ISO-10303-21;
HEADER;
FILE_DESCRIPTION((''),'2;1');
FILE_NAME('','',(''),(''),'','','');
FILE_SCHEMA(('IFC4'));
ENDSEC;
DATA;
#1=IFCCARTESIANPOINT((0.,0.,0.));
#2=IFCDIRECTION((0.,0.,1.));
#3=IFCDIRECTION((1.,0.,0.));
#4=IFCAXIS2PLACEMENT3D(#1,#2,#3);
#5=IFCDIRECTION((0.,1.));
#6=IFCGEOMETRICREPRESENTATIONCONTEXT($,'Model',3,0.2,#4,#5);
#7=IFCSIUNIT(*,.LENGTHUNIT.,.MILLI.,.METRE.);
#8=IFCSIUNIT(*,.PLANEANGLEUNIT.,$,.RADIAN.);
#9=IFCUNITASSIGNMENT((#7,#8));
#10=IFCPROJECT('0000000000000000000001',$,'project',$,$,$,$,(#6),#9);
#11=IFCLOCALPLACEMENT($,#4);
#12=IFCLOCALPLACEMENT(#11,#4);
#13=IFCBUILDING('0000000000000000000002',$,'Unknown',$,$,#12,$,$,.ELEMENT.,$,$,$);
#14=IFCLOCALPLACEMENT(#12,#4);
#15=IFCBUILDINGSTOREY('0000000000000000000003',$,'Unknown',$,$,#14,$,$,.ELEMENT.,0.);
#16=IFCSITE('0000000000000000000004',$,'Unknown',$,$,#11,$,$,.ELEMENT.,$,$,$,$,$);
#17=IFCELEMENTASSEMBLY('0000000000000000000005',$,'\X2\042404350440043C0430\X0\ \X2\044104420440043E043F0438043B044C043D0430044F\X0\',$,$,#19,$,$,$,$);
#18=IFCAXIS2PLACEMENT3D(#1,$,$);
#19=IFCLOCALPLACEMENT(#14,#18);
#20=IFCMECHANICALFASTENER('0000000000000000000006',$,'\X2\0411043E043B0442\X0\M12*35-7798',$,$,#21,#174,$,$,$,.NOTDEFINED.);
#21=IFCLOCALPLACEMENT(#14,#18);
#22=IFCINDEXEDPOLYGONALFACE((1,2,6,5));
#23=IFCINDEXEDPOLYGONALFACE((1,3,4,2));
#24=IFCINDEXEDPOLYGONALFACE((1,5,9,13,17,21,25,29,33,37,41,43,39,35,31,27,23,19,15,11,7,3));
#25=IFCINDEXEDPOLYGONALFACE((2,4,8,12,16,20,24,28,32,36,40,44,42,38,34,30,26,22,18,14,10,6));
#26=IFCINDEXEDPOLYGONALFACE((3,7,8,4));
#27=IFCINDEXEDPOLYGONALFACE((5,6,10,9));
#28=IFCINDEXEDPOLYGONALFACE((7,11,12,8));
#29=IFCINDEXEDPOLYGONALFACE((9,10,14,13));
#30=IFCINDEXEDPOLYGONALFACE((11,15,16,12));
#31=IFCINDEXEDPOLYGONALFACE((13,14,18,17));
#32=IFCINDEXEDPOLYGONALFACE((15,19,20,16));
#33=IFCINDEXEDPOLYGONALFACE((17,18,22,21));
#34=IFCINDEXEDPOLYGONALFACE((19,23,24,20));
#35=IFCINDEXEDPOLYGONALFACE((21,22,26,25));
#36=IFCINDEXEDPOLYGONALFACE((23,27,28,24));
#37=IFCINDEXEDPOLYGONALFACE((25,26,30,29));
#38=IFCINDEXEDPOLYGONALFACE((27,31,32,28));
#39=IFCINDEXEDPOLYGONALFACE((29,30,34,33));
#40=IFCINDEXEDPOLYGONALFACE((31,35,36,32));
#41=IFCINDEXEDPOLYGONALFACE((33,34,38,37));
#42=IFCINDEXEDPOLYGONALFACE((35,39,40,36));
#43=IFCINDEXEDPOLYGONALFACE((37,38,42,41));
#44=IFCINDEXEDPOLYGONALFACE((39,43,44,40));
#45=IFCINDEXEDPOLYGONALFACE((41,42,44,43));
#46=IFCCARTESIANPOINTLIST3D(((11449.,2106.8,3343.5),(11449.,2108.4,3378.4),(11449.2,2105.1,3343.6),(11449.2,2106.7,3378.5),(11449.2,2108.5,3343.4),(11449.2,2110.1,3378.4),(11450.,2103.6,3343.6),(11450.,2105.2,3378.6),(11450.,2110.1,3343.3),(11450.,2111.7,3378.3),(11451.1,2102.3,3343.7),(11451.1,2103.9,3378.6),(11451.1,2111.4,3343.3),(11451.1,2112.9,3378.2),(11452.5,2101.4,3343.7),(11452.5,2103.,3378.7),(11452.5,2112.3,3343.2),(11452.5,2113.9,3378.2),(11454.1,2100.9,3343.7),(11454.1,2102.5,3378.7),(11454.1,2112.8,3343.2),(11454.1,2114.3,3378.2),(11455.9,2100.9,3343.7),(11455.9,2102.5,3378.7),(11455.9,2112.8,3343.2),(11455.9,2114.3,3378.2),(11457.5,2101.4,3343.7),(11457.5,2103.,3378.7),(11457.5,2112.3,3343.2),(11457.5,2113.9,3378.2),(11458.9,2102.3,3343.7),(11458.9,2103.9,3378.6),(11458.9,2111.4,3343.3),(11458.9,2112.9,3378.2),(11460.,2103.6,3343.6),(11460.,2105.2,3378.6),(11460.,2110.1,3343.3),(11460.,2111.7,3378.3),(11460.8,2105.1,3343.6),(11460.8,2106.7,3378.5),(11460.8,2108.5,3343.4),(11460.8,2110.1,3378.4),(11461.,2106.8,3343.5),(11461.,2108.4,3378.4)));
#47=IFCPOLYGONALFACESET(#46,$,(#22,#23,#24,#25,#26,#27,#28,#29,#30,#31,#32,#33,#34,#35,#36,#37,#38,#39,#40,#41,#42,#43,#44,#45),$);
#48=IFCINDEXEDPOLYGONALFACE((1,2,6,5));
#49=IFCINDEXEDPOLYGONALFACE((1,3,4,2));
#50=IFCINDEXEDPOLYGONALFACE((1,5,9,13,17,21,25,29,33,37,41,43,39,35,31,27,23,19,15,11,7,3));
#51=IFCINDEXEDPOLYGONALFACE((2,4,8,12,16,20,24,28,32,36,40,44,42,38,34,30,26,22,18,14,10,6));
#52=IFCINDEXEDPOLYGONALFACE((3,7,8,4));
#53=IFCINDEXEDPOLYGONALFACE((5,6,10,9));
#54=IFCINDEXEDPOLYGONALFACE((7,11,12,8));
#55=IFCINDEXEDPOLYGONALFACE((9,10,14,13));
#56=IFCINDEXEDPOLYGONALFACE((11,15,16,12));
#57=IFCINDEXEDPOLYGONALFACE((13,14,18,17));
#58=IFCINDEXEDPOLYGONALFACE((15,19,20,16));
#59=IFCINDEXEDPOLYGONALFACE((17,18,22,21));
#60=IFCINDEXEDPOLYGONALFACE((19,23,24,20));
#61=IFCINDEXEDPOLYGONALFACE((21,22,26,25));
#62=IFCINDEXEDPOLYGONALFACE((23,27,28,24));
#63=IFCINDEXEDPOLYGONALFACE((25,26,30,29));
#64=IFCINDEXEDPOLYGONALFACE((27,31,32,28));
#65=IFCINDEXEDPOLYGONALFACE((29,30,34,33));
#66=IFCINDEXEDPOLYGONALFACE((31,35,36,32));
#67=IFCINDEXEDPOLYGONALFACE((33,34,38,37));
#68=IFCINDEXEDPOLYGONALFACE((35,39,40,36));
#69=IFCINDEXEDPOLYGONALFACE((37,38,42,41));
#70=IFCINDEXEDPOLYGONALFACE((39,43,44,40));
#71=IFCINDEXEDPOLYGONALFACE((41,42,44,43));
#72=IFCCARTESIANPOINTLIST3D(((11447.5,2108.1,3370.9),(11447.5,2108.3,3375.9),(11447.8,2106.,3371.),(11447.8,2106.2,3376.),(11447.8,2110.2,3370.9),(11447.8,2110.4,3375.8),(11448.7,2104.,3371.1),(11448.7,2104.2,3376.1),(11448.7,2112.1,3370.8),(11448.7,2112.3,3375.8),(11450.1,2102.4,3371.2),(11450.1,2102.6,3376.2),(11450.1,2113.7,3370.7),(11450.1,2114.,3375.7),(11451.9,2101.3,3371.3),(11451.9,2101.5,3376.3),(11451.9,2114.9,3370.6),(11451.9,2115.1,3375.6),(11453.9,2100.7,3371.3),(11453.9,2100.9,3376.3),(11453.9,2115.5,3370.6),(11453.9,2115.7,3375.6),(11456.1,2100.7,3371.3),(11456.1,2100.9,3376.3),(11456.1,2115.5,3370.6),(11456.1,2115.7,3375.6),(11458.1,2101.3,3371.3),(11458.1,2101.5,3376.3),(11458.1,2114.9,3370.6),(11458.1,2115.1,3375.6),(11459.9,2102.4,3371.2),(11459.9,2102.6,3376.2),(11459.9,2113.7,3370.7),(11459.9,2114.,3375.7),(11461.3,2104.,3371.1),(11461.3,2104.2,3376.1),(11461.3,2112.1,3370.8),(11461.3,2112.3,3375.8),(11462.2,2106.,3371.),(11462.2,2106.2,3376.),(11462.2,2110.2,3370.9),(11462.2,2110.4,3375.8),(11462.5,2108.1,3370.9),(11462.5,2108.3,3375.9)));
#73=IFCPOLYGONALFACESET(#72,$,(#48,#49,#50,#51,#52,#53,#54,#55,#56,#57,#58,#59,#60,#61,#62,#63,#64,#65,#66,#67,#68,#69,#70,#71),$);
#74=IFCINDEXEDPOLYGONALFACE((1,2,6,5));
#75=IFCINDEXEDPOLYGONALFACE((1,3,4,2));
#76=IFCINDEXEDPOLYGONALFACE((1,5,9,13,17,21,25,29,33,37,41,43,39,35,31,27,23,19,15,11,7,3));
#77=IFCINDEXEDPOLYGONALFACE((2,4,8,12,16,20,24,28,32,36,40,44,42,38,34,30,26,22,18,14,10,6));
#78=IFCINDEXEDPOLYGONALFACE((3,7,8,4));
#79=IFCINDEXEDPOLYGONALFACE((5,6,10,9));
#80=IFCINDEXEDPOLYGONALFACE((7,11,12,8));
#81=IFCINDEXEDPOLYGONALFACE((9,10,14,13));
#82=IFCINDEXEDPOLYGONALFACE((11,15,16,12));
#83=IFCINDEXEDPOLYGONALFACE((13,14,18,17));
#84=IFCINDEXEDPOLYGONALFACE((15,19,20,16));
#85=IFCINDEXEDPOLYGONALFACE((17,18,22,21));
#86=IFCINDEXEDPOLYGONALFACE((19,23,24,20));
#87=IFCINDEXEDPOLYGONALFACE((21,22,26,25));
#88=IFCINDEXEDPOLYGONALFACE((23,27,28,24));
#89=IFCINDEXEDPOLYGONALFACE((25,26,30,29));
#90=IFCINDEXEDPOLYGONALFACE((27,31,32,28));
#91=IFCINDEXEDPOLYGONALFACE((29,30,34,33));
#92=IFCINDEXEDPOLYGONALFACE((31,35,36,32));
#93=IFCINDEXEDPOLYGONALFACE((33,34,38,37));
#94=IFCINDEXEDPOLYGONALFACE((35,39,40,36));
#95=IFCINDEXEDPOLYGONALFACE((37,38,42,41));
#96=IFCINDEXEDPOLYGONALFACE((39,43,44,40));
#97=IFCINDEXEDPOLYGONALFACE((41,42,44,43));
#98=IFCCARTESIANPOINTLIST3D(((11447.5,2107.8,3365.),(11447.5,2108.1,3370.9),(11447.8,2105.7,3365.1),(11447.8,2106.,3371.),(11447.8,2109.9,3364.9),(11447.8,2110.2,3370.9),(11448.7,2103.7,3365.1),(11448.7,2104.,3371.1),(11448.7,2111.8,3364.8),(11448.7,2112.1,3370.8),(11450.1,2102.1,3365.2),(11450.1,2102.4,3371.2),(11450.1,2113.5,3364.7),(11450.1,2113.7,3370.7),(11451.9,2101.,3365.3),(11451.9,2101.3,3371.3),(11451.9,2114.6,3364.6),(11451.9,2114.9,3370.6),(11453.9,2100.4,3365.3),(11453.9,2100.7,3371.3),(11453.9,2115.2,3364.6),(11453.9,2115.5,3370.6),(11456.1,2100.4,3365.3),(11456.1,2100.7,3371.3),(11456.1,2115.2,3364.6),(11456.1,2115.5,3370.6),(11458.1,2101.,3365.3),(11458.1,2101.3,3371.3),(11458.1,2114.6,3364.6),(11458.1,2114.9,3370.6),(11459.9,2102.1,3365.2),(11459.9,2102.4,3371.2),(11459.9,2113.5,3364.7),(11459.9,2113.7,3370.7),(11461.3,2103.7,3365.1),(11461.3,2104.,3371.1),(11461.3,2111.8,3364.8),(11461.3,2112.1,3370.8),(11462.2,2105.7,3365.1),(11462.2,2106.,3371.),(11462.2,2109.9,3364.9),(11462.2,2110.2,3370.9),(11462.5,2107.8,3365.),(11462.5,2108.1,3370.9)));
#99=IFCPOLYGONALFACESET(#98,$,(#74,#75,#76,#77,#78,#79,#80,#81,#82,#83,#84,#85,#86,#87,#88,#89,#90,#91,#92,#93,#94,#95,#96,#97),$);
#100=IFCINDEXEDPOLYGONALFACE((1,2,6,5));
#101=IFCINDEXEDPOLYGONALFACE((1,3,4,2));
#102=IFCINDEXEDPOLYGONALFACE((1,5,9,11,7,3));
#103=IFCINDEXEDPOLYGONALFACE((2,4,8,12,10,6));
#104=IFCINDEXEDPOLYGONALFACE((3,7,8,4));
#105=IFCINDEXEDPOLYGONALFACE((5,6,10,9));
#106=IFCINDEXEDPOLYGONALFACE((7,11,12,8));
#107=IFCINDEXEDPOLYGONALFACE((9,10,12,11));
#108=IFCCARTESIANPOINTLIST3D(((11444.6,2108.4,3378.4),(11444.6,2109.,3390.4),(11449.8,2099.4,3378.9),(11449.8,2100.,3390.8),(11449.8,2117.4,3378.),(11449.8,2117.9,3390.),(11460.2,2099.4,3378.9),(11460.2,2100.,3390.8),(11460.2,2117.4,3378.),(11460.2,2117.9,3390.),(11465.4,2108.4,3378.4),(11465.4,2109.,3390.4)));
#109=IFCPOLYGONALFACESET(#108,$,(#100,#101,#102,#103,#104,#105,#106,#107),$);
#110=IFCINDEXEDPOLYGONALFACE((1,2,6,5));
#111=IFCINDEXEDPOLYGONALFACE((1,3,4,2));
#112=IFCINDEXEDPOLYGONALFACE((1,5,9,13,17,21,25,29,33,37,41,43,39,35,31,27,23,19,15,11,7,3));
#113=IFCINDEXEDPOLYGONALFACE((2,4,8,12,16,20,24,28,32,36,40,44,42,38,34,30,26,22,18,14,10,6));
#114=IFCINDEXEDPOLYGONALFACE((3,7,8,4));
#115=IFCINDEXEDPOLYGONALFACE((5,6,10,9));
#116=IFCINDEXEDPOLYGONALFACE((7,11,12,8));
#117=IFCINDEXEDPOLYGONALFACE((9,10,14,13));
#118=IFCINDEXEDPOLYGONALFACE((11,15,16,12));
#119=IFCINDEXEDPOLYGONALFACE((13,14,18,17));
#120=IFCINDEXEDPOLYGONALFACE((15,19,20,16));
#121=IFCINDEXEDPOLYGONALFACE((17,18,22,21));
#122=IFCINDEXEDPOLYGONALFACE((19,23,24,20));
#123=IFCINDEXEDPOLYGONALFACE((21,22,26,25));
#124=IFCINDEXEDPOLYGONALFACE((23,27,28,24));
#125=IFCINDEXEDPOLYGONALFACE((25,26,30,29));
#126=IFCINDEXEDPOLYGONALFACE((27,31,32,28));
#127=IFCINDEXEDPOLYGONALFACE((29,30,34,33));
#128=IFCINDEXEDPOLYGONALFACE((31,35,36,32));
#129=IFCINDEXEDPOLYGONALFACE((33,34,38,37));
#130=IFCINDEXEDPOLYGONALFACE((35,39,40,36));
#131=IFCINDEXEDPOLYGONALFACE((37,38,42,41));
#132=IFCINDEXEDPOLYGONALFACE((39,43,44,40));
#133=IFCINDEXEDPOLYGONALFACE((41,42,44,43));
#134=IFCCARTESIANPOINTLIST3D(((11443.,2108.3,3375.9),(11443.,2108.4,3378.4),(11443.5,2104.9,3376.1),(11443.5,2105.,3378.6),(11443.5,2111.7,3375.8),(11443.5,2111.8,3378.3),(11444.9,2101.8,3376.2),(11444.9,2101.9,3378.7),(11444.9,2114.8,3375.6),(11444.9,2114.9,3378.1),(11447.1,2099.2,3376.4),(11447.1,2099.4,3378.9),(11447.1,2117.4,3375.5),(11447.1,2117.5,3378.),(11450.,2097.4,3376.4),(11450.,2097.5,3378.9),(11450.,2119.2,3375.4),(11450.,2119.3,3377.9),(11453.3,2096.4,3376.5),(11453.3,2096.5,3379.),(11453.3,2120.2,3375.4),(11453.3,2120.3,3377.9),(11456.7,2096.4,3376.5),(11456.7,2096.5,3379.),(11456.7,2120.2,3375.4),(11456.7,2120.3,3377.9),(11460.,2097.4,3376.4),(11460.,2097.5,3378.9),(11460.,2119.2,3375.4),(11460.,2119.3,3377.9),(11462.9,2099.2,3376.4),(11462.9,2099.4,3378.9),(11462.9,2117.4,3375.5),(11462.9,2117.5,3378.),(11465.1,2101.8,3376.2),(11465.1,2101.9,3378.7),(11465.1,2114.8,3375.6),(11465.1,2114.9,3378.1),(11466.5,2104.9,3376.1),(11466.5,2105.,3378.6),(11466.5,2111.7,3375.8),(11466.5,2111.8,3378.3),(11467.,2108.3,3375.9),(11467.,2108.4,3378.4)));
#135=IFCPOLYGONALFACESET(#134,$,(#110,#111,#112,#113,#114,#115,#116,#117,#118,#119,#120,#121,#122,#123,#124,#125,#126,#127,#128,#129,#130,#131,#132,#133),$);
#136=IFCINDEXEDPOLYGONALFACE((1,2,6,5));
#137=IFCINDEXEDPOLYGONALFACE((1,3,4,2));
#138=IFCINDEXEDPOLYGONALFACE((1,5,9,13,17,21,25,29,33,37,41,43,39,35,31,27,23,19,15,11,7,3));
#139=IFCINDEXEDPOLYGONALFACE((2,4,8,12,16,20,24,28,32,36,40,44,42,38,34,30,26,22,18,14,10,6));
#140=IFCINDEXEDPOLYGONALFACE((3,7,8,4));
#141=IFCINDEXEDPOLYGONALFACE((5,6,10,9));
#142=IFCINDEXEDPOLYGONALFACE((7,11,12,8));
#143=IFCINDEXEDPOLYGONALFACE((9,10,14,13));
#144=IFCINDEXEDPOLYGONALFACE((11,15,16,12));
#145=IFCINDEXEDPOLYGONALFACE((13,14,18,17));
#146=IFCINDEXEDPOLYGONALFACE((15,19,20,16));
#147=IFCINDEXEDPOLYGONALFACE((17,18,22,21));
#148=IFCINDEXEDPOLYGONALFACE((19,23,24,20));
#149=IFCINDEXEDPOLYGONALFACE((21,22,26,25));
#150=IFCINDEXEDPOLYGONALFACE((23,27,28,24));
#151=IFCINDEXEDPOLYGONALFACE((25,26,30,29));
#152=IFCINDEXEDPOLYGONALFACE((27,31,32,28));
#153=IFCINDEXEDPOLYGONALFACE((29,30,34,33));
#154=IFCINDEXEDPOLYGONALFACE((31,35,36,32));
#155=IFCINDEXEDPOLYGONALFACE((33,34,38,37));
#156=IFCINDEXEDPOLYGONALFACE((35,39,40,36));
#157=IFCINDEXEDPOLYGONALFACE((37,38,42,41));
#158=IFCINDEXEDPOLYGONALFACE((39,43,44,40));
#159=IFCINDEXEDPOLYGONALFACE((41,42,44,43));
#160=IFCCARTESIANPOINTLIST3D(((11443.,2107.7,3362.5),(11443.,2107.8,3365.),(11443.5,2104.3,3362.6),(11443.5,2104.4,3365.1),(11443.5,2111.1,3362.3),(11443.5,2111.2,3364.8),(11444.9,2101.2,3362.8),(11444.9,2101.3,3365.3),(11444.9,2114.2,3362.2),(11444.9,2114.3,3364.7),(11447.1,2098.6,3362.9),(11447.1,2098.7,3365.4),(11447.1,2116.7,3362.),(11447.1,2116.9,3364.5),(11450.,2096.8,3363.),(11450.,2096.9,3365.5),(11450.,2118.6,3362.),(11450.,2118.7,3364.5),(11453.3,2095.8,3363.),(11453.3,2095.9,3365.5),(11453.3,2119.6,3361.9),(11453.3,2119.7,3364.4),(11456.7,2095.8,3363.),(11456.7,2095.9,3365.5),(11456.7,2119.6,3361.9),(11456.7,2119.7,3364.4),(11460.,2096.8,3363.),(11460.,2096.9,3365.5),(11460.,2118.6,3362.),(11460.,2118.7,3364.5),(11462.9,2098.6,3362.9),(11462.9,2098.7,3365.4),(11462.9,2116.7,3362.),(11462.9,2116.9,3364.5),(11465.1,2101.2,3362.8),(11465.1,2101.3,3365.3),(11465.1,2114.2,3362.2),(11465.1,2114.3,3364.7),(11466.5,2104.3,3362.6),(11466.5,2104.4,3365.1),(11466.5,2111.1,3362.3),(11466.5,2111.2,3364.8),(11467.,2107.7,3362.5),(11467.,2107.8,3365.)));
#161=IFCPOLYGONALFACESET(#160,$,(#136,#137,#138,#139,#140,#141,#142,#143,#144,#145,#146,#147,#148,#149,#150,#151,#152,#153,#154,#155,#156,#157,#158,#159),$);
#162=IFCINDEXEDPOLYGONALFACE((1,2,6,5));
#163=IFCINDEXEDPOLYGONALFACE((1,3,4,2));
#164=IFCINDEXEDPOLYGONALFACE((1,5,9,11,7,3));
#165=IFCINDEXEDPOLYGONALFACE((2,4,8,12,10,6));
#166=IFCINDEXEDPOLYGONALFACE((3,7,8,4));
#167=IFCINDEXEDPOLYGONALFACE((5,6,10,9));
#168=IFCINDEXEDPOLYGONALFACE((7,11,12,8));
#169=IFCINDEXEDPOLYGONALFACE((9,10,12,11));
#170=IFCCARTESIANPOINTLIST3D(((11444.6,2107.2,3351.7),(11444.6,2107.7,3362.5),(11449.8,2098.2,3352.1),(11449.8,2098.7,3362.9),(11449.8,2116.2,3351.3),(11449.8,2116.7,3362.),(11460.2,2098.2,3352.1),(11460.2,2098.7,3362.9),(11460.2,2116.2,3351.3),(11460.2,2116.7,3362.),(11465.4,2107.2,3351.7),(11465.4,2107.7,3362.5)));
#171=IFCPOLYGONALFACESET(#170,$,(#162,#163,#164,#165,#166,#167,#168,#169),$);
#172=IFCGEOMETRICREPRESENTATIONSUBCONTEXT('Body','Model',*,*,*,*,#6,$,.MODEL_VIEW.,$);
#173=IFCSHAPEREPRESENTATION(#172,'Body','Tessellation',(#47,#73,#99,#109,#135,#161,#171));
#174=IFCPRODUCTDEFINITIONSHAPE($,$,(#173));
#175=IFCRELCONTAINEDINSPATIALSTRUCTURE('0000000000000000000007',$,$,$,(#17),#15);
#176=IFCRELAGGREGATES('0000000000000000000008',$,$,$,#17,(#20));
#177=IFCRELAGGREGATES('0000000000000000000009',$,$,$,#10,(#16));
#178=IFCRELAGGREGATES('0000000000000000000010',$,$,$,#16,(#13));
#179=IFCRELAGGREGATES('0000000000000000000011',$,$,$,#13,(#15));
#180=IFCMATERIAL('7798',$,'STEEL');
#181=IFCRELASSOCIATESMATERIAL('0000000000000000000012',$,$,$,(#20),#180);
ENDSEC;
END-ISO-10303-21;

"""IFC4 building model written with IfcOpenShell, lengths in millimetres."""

from ifc_helpers import new_model, si_unit, direction, frame, origin_with_axes, place, context, subcontext, project, spatial, line, arc, indexed_curve, outline, extrude, source, transform, mapped, material, element, aggregate, save


model = new_model("IFC4")

# Units and contexts
model_context = context("Model", 3, precision=0.2, world=origin_with_axes(), true_north=direction((0.0, 1.0)))
body_context = subcontext(model_context, "Body", "Model", "MODEL_VIEW")
ifc_project = project(units=[si_unit("LENGTHUNIT", "METRE", prefix="MILLI"), si_unit("PLANEANGLEUNIT", "RADIAN")], contexts=[model_context])

# Site, building, storey
site_placement = place(None, origin_with_axes())
site = spatial("IfcSite", under=ifc_project, at=site_placement, Name="Unknown", CompositionType="ELEMENT")
building_placement = place(site_placement, origin_with_axes())
building = spatial("IfcBuilding", under=site, at=building_placement, Name="Unknown", CompositionType="ELEMENT")
storey_placement = place(building_placement, origin_with_axes())
storey = spatial("IfcBuildingStorey", under=building, at=storey_placement, Name="Unknown", CompositionType="ELEMENT", Elevation=0.0)

# Element assembly
assembly_1_placement = place(storey_placement, frame((11400.0, 88.6, 3426.7), z_axis=(1.0, 0.0, 0.0), x_axis=(0.0, 0.998969, -0.045408)))
assembly_1 = element("IfcElementAssembly", 1, at=assembly_1_placement, inside=storey, Name="Ферма стропильная")

# Mechanical fastener
ifc_material_1 = material(Name="7798", Category="STEEL")
shared_shape_1 = source(origin_with_axes(), body_context, "Body", "SweptSolid", [
    extrude(outline(indexed_curve([(6.0, 0.0), (0.0, 6.0), (-6.0, 0.0), (0.0, -6.0)], segments=[arc(1, 2, 3), arc(3, 4, 1)])), frame((0.0, 0.0, 7.5), z_axis=(0.0, 0.0, -1.0), x_axis=(0.0, 1.0, 0.0)), (0.0, 0.0, 1.0), 35.0),
    extrude(outline(indexed_curve([(7.5, 0.0), (0.0, 7.5), (-7.5, 0.0), (0.0, -7.5)], segments=[arc(1, 2, 3), arc(3, 4, 1)])), frame((0.0, 0.0, 5.0), z_axis=(0.0, 0.0, -1.0), x_axis=(0.0, 1.0, 0.0)), (0.0, 0.0, 1.0), 5.0),
    extrude(outline(indexed_curve([(7.5, 0.0), (0.0, 7.5), (-7.5, 0.0), (0.0, -7.5)], segments=[arc(1, 2, 3), arc(3, 4, 1)])), frame((0.0, 0.0, 0.0), z_axis=(0.0, 0.0, -1.0), x_axis=(0.0, 1.0, 0.0)), (0.0, 0.0, 1.0), 6.0),
    extrude(outline(indexed_curve([(10.4, 0.0), (5.2, 9.0), (-5.2, 9.0), (-10.4, 0.0), (-5.2, -9.0), (5.2, -9.0)], segments=[line(1, 2, 3, 4, 5, 6, 1)])), frame((0.0, 0.0, 19.5), z_axis=(0.0, 0.0, -1.0), x_axis=(0.0, 1.0, 0.0)), (0.0, 0.0, 1.0), 12.0),
    extrude(outline(indexed_curve([(12.0, 0.0), (0.0, 12.0), (-12.0, 0.0), (0.0, -12.0)], segments=[arc(1, 2, 3), arc(3, 4, 1)])), frame((0.0, 0.0, 7.5), z_axis=(0.0, 0.0, -1.0), x_axis=(0.0, 1.0, 0.0)), (0.0, 0.0, 1.0), 2.5),
    extrude(outline(indexed_curve([(12.0, 0.0), (0.0, 12.0), (-12.0, 0.0), (0.0, -12.0)], segments=[arc(1, 2, 3), arc(3, 4, 1)])), frame((0.0, 0.0, -6.0), z_axis=(0.0, 0.0, -1.0), x_axis=(0.0, 1.0, 0.0)), (0.0, 0.0, 1.0), 2.5),
    extrude(outline(indexed_curve([(10.4, 0.0), (5.2, 9.0), (-5.2, 9.0), (-10.4, 0.0), (-5.2, -9.0), (5.2, -9.0)], segments=[line(1, 2, 3, 4, 5, 6, 1)])), frame((0.0, 0.0, -8.5), z_axis=(0.0, 0.0, -1.0), x_axis=(0.0, 1.0, 0.0)), (0.0, 0.0, 1.0), 10.8),
])
mechanical_fastener_1_placement = place(assembly_1_placement, frame((2019.9, 36.0, 55.0), z_axis=(0.0, 1.0, 0.0), x_axis=(1.0, 0.0, 0.0)))
mechanical_fastener_1 = element("IfcMechanicalFastener", 2, at=mechanical_fastener_1_placement, material=ifc_material_1, Name="БолтM12*35-7798", PredefinedType="NOTDEFINED", context=body_context, shape_type="MappedRepresentation", body=[
    mapped(shared_shape_1, transform((0.0, 0.0, 0.0))),
])
aggregate(assembly_1, [mechanical_fastener_1])

save(model, "model.ifc")
